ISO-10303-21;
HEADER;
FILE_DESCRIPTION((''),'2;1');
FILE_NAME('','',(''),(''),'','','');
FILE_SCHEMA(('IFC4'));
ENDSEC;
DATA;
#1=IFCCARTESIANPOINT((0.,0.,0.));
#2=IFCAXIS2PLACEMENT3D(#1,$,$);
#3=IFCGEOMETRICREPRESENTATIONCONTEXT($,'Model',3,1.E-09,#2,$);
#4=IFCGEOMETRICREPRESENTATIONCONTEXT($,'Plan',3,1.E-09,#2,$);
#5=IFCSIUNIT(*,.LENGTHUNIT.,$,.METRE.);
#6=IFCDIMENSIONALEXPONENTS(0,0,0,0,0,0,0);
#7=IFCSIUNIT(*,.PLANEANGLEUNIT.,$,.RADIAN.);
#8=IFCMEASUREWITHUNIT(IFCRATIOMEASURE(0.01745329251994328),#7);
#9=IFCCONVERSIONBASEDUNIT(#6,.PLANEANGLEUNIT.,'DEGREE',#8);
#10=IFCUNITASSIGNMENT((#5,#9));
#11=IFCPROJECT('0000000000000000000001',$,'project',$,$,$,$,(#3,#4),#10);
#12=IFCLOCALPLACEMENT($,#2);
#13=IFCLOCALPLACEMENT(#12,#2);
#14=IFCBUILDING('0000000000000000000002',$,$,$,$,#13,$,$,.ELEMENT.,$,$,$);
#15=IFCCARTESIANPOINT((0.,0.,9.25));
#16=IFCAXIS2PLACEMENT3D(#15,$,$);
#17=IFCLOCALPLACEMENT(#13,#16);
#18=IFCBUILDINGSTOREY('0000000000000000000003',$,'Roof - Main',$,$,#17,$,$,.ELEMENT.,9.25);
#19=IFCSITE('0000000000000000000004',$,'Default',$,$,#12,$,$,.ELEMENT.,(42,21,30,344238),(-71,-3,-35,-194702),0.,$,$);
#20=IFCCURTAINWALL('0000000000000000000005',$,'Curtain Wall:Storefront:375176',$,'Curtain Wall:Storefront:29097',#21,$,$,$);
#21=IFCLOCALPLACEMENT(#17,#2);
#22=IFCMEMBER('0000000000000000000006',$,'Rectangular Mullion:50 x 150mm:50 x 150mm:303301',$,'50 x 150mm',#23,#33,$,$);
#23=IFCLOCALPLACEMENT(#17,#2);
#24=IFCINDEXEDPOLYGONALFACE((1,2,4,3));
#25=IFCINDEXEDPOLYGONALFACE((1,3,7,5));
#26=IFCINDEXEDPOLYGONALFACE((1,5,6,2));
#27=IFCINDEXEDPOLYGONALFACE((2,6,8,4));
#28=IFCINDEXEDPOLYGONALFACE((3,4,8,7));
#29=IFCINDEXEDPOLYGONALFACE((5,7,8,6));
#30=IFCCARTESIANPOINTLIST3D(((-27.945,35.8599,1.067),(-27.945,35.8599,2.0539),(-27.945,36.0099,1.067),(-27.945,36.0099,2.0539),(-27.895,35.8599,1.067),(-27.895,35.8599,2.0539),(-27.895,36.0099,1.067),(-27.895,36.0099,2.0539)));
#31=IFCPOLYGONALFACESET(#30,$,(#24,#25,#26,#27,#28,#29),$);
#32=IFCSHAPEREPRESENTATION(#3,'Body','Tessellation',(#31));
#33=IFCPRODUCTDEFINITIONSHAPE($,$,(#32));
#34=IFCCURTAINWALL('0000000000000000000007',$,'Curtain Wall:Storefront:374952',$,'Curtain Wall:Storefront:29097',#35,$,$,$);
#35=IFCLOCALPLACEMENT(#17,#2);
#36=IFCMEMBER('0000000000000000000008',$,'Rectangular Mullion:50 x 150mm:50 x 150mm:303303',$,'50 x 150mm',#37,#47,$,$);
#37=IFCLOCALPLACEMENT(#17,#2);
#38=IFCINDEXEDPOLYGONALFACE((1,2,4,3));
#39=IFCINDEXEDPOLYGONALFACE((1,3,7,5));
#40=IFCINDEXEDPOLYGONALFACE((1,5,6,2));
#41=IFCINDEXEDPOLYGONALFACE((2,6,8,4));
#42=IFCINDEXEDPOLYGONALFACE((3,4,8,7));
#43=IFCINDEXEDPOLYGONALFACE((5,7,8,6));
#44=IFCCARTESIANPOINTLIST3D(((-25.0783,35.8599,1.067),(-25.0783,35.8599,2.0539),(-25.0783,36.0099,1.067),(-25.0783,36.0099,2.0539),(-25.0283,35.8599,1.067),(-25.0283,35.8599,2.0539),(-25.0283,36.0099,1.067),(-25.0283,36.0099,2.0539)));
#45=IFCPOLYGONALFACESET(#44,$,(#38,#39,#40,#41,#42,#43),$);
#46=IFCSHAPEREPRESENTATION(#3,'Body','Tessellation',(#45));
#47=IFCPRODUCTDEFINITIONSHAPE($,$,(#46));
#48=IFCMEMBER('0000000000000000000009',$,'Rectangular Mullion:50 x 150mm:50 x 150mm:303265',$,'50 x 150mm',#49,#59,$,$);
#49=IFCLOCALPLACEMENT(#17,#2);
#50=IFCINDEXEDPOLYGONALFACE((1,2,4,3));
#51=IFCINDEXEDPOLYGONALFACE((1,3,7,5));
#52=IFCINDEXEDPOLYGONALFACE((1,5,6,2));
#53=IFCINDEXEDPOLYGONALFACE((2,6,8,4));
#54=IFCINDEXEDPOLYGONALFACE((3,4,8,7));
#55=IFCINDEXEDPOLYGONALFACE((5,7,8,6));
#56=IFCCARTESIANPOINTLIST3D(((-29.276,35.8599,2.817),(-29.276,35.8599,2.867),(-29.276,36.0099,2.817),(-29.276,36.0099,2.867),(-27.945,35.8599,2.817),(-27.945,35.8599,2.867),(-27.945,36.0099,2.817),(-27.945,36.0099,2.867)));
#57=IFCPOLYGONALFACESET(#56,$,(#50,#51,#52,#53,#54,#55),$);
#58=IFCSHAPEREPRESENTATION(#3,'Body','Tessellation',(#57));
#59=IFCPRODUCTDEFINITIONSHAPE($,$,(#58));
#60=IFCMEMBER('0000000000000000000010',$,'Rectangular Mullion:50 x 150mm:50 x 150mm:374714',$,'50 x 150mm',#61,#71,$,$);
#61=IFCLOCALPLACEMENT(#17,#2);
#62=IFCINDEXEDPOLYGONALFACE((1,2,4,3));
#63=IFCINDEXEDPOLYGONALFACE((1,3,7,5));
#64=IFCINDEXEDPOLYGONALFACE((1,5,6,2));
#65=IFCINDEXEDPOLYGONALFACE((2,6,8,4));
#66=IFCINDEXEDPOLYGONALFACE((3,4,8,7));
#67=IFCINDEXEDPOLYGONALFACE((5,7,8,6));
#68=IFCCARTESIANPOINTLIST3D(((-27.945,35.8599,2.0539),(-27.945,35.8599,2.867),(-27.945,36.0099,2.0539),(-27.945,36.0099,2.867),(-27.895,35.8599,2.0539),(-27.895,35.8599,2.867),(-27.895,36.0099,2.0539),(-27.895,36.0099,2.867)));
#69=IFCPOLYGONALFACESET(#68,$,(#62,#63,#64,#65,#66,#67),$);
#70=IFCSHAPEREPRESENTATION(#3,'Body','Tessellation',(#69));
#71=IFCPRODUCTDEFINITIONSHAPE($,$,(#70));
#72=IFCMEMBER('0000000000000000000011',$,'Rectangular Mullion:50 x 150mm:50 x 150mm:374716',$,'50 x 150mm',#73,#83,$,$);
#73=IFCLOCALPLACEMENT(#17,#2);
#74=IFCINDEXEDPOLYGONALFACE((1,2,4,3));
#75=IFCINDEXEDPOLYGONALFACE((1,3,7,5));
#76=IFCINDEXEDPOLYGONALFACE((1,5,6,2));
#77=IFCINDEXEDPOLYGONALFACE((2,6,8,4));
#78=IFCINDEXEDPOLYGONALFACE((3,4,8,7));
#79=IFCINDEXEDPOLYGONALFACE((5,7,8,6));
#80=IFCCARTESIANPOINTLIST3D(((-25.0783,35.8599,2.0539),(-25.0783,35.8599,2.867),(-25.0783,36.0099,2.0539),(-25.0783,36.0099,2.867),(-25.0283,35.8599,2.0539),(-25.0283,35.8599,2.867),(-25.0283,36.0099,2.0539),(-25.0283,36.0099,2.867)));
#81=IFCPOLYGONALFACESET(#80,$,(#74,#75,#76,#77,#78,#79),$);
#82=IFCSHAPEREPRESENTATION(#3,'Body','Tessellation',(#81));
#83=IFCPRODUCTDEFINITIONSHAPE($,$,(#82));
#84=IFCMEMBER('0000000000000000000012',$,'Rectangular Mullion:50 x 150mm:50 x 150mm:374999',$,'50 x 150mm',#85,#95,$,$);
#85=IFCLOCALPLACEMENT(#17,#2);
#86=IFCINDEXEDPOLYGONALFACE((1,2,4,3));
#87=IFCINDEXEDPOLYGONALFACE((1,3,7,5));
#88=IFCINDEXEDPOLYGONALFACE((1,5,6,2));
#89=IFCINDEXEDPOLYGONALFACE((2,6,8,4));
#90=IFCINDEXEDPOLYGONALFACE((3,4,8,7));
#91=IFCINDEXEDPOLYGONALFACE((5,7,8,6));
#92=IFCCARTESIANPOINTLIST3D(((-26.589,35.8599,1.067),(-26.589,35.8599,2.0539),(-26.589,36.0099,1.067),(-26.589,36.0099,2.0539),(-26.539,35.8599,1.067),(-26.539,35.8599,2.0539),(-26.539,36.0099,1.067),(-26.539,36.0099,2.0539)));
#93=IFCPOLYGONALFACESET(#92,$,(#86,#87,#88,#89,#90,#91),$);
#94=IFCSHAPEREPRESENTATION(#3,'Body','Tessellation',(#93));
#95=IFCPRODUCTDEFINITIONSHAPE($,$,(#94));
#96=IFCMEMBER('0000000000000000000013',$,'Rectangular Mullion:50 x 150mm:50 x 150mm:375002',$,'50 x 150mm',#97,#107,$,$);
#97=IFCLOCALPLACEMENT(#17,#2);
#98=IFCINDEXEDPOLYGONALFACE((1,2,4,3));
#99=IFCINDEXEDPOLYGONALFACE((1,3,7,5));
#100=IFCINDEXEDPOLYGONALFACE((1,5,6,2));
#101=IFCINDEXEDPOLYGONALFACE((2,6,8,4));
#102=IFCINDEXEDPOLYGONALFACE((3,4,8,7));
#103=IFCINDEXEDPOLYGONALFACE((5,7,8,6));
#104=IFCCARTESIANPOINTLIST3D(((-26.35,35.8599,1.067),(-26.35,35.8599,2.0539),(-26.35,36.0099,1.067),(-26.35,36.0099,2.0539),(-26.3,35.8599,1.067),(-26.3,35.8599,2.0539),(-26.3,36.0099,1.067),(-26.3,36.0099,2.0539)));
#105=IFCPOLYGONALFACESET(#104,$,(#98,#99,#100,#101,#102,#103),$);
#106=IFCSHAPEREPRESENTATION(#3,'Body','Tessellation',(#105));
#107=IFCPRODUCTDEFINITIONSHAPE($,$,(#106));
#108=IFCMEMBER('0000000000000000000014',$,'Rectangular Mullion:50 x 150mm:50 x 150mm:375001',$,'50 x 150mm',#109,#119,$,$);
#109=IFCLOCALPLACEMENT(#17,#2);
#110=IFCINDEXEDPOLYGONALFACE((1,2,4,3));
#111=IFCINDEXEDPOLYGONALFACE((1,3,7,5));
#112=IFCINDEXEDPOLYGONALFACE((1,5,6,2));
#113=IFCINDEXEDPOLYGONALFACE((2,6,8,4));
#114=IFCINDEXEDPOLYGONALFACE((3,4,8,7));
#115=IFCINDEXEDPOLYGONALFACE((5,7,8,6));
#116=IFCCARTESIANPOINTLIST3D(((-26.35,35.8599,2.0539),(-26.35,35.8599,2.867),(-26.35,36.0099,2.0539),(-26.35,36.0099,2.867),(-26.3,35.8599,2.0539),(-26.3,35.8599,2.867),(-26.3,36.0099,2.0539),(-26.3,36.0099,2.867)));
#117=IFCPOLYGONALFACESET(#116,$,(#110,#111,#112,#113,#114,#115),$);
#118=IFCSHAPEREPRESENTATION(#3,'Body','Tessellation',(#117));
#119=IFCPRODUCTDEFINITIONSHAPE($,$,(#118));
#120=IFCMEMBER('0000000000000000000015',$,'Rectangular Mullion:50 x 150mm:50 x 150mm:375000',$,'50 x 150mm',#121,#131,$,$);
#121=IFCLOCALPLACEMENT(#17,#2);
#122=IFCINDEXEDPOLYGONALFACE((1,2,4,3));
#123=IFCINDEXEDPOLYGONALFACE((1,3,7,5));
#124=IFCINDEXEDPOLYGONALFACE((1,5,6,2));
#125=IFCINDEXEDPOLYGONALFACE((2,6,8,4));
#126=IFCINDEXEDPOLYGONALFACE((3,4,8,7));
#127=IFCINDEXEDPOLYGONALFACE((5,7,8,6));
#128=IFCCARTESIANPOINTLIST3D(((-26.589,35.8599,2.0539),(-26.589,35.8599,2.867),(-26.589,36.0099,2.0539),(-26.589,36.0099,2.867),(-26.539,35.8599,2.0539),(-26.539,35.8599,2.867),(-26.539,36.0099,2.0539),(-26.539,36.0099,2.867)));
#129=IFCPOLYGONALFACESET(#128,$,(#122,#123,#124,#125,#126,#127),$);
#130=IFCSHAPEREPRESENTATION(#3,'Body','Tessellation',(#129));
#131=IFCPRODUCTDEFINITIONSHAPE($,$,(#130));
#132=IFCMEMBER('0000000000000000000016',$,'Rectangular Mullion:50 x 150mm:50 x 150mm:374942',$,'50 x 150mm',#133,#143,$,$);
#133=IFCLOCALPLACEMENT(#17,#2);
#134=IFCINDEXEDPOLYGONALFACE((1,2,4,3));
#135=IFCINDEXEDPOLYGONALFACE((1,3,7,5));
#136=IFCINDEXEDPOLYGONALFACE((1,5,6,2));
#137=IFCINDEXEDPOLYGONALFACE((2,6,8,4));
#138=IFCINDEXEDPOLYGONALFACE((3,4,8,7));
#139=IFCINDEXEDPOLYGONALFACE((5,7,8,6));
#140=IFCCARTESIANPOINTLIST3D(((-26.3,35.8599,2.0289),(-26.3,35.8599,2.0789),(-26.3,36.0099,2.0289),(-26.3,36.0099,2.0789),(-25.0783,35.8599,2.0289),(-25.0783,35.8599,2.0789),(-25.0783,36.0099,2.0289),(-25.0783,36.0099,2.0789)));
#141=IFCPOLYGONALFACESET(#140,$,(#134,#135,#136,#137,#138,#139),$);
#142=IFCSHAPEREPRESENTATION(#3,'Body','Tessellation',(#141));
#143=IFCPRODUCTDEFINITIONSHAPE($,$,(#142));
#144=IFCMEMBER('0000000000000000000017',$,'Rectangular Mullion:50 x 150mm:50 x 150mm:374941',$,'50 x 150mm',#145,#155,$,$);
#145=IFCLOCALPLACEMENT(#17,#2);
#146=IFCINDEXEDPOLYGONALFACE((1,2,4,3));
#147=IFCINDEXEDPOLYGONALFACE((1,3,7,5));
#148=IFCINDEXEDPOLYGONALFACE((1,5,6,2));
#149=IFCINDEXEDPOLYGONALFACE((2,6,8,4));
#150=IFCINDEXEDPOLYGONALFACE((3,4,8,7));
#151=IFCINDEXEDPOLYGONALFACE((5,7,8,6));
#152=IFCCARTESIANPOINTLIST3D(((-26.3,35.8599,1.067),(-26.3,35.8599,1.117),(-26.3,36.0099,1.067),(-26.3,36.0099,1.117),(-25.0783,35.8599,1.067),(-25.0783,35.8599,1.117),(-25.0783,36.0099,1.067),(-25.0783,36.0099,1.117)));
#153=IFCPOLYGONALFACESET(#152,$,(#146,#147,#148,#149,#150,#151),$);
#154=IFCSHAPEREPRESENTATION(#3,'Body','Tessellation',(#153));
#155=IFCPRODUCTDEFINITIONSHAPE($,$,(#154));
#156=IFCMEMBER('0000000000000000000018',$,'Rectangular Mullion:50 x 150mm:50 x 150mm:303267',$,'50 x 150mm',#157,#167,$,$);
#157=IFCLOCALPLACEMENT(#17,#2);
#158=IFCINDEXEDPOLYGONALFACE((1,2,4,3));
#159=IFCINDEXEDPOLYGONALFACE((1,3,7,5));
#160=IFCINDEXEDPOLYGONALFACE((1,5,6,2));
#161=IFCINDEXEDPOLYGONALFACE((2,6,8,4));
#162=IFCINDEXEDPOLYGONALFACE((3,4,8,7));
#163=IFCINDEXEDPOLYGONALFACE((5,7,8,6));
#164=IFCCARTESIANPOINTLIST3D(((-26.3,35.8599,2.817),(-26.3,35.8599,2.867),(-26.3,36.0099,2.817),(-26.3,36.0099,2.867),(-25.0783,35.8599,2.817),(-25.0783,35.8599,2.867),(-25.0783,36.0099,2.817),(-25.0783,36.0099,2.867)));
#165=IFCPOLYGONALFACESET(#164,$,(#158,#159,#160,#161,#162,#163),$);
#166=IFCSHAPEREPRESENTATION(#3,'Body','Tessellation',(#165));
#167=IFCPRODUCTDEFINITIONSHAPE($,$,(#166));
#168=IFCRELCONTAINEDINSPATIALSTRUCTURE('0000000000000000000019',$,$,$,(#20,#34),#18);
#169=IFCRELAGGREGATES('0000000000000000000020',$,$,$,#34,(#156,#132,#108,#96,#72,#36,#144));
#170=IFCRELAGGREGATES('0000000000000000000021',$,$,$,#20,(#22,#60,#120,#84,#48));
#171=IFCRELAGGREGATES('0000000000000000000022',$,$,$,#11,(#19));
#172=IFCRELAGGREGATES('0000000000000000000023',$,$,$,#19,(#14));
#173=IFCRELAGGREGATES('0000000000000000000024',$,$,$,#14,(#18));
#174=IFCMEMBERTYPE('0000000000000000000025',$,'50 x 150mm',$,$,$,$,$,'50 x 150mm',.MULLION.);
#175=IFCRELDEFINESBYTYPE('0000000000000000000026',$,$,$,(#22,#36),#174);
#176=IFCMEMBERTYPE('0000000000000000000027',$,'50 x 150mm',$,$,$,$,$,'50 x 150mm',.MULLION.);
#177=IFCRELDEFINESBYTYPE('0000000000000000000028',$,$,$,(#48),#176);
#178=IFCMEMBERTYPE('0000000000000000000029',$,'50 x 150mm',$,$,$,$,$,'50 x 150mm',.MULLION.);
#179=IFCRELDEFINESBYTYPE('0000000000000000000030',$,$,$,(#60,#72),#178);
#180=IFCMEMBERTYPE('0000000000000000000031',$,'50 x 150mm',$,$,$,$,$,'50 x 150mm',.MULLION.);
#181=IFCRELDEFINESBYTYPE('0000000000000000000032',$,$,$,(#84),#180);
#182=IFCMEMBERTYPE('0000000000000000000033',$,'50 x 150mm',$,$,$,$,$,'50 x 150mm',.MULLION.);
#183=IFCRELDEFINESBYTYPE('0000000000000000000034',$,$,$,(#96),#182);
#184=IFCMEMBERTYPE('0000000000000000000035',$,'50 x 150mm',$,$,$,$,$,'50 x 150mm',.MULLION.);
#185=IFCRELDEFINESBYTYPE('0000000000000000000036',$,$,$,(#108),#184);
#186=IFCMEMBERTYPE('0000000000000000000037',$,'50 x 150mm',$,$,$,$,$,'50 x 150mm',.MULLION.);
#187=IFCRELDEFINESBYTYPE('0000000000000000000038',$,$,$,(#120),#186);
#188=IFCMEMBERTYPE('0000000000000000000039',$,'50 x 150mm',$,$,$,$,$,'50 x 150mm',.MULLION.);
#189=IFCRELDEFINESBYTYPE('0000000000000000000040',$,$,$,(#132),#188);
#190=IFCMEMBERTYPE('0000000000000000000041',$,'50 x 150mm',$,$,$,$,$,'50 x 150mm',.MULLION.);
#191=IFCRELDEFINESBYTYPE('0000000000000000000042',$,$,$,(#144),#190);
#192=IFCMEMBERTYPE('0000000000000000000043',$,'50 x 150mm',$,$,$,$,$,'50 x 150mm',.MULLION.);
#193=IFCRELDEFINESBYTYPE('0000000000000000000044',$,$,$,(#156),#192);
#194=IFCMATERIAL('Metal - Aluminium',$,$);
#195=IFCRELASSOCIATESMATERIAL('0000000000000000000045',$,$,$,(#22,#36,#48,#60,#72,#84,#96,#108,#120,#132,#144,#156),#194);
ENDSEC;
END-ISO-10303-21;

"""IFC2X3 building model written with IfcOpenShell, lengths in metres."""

from ifc_helpers import new_model, entity, si_unit, converted_unit, frame, origin, origin_2d_with_axis, place, context, project, spatial, rectangle, extrude, source, transform, mapped, material, type_object, type_shapes, element, aggregate, save


model = new_model("IFC2X3")

# Units and contexts
model_context = context("Model", 3, precision=1e-09, world=origin())
plan_context = context("Plan", 3, precision=1e-09, world=origin())
ifc_project = project(units=[si_unit("LENGTHUNIT", "METRE"), converted_unit("PLANEANGLEUNIT", "DEGREE", entity("IfcRatioMeasure", 0.01745329251994328), si_unit("PLANEANGLEUNIT", "RADIAN"), dimensions=[0, 0, 0, 0, 0, 0, 0])], contexts=[model_context, plan_context])

# Site, building, storey
site_placement = place(None, origin())
site = spatial("IfcSite", under=ifc_project, at=site_placement, Name="Default", CompositionType="ELEMENT", RefLatitude=(42, 21, 30, 344238), RefLongitude=(-71, -3, -35, -194702), RefElevation=0.0)
building_placement = place(site_placement, origin())
building = spatial("IfcBuilding", under=site, at=building_placement, CompositionType="ELEMENT")
storey_placement = place(building_placement, frame((0.0, 0.0, 9.25)))
storey = spatial("IfcBuildingStorey", under=building, at=storey_placement, Name="Roof - Main", CompositionType="ELEMENT", Elevation=9.25)

# Curtain walls, members
curtain_wall_1_placement = place(storey_placement, origin())
curtain_wall_1 = element("IfcCurtainWall", 1, at=curtain_wall_1_placement, inside=storey, Name="Curtain Wall:Storefront:375176", ObjectType="Curtain Wall:Storefront:29097")
ifc_material_1 = material(Name="Metal - Aluminium")
member_type_1 = type_object("IfcMemberType", Name="50 x 150mm", ElementType="50 x 150mm", PredefinedType="MULLION")
shared_shape_1 = source(origin(), model_context, "Body", "SweptSolid", [
    extrude(rectangle(XDim=0.05, YDim=0.15, at=origin_2d_with_axis()), frame((0.0, 0.0, -0.9869), z_axis=(0.0, 0.0, 1.0), x_axis=(-1.0, 0.0, 0.0)), (0.0, 0.0, 1.0), 0.9869),
])
type_shapes(member_type_1, [shared_shape_1])
member_1_placement = place(storey_placement, frame((-27.92, 35.9349, 1.067), z_axis=(0.0, 0.0, -1.0), x_axis=(1.0, 0.0, 0.0)))
member_1 = element("IfcMember", 2, at=member_1_placement, type_object=member_type_1, material=ifc_material_1, Name="Rectangular Mullion:50 x 150mm:50 x 150mm:303301", ObjectType="50 x 150mm", context=model_context, shape_type="MappedRepresentation", body=[
    mapped(shared_shape_1, transform((0.0, 0.0, 0.0), scale=1.0)),
])
curtain_wall_2_placement = place(storey_placement, origin())
curtain_wall_2 = element("IfcCurtainWall", 3, at=curtain_wall_2_placement, inside=storey, Name="Curtain Wall:Storefront:374952", ObjectType="Curtain Wall:Storefront:29097")
member_2_placement = place(storey_placement, frame((-25.0533, 35.9349, 1.067), z_axis=(0.0, 0.0, -1.0), x_axis=(1.0, 0.0, 0.0)))
member_2 = element("IfcMember", 4, at=member_2_placement, type_object=member_type_1, material=ifc_material_1, Name="Rectangular Mullion:50 x 150mm:50 x 150mm:303303", ObjectType="50 x 150mm", context=model_context, shape_type="MappedRepresentation", body=[
    mapped(shared_shape_1, transform((0.0, 0.0, 0.0), scale=1.0)),
])

# Members
member_type_2 = type_object("IfcMemberType", Name="50 x 150mm", ElementType="50 x 150mm", PredefinedType="MULLION")
shared_shape_2 = source(origin(), model_context, "Body", "SweptSolid", [
    extrude(rectangle(XDim=0.05, YDim=0.15, at=origin_2d_with_axis()), frame((-0.025, 0.0, -1.331), z_axis=(0.0, 0.0, 1.0), x_axis=(-1.0, 0.0, 0.0)), (0.0, 0.0, 1.0), 1.331),
])
type_shapes(member_type_2, [shared_shape_2])
member_3_placement = place(storey_placement, frame((-27.945, 35.9349, 2.867), z_axis=(1.0, 0.0, 0.0), x_axis=(0.0, 0.0, 1.0)))
member_3 = element("IfcMember", 5, at=member_3_placement, type_object=member_type_2, material=ifc_material_1, Name="Rectangular Mullion:50 x 150mm:50 x 150mm:303265", ObjectType="50 x 150mm", context=model_context, shape_type="MappedRepresentation", body=[
    mapped(shared_shape_2, transform((0.0, 0.0, 0.0), scale=1.0)),
])
member_type_3 = type_object("IfcMemberType", Name="50 x 150mm", ElementType="50 x 150mm", PredefinedType="MULLION")
shared_shape_3 = source(origin(), model_context, "Body", "SweptSolid", [
    extrude(rectangle(XDim=0.05, YDim=0.15, at=origin_2d_with_axis()), frame((0.0, 0.0, -0.8131), z_axis=(0.0, 0.0, 1.0), x_axis=(-1.0, 0.0, 0.0)), (0.0, 0.0, 1.0), 0.8131),
])
type_shapes(member_type_3, [shared_shape_3])
member_4_placement = place(storey_placement, frame((-27.92, 35.9349, 2.0539), z_axis=(0.0, 0.0, -1.0), x_axis=(1.0, 0.0, 0.0)))
member_4 = element("IfcMember", 6, at=member_4_placement, type_object=member_type_3, material=ifc_material_1, Name="Rectangular Mullion:50 x 150mm:50 x 150mm:374714", ObjectType="50 x 150mm", context=model_context, shape_type="MappedRepresentation", body=[
    mapped(shared_shape_3, transform((0.0, 0.0, 0.0), scale=1.0)),
])
member_5_placement = place(storey_placement, frame((-25.0533, 35.9349, 2.0539), z_axis=(0.0, 0.0, -1.0), x_axis=(1.0, 0.0, 0.0)))
member_5 = element("IfcMember", 7, at=member_5_placement, type_object=member_type_3, material=ifc_material_1, Name="Rectangular Mullion:50 x 150mm:50 x 150mm:374716", ObjectType="50 x 150mm", context=model_context, shape_type="MappedRepresentation", body=[
    mapped(shared_shape_3, transform((0.0, 0.0, 0.0), scale=1.0)),
])
member_type_4 = type_object("IfcMemberType", Name="50 x 150mm", ElementType="50 x 150mm", PredefinedType="MULLION")
shared_shape_4 = source(origin(), model_context, "Body", "SweptSolid", [
    extrude(rectangle(XDim=0.05, YDim=0.15, at=origin_2d_with_axis()), frame((-0.025, 0.0, -0.9869), z_axis=(0.0, 0.0, 1.0), x_axis=(-1.0, 0.0, 0.0)), (0.0, 0.0, 1.0), 0.9869),
])
type_shapes(member_type_4, [shared_shape_4])
member_6_placement = place(storey_placement, frame((-26.539, 35.9349, 1.067), z_axis=(0.0, 0.0, -1.0), x_axis=(1.0, 0.0, 0.0)))
member_6 = element("IfcMember", 8, at=member_6_placement, type_object=member_type_4, material=ifc_material_1, Name="Rectangular Mullion:50 x 150mm:50 x 150mm:374999", ObjectType="50 x 150mm", context=model_context, shape_type="MappedRepresentation", body=[
    mapped(shared_shape_4, transform((0.0, 0.0, 0.0), scale=1.0)),
])
member_type_5 = type_object("IfcMemberType", Name="50 x 150mm", ElementType="50 x 150mm", PredefinedType="MULLION")
shared_shape_5 = source(origin(), model_context, "Body", "SweptSolid", [
    extrude(rectangle(XDim=0.05, YDim=0.15, at=origin_2d_with_axis()), frame((-0.025, 0.0, -0.9869), z_axis=(0.0, 0.0, 1.0), x_axis=(-1.0, 0.0, 0.0)), (0.0, 0.0, 1.0), 0.9869),
])
type_shapes(member_type_5, [shared_shape_5])
member_7_placement = place(storey_placement, frame((-26.35, 35.9349, 2.0539), z_axis=(0.0, 0.0, 1.0), x_axis=(-1.0, 0.0, 0.0)))
member_7 = element("IfcMember", 9, at=member_7_placement, type_object=member_type_5, material=ifc_material_1, Name="Rectangular Mullion:50 x 150mm:50 x 150mm:375002", ObjectType="50 x 150mm", context=model_context, shape_type="MappedRepresentation", body=[
    mapped(shared_shape_5, transform((0.0, 0.0, 0.0), scale=1.0)),
])
member_type_6 = type_object("IfcMemberType", Name="50 x 150mm", ElementType="50 x 150mm", PredefinedType="MULLION")
shared_shape_6 = source(origin(), model_context, "Body", "SweptSolid", [
    extrude(rectangle(XDim=0.05, YDim=0.15, at=origin_2d_with_axis()), frame((-0.025, 0.0, -0.8131), z_axis=(0.0, 0.0, 1.0), x_axis=(-1.0, 0.0, 0.0)), (0.0, 0.0, 1.0), 0.8131),
])
type_shapes(member_type_6, [shared_shape_6])
member_8_placement = place(storey_placement, frame((-26.35, 35.9349, 2.867), z_axis=(0.0, 0.0, 1.0), x_axis=(-1.0, 0.0, 0.0)))
member_8 = element("IfcMember", 10, at=member_8_placement, type_object=member_type_6, material=ifc_material_1, Name="Rectangular Mullion:50 x 150mm:50 x 150mm:375001", ObjectType="50 x 150mm", context=model_context, shape_type="MappedRepresentation", body=[
    mapped(shared_shape_6, transform((0.0, 0.0, 0.0), scale=1.0)),
])
member_type_7 = type_object("IfcMemberType", Name="50 x 150mm", ElementType="50 x 150mm", PredefinedType="MULLION")
shared_shape_7 = source(origin(), model_context, "Body", "SweptSolid", [
    extrude(rectangle(XDim=0.05, YDim=0.15, at=origin_2d_with_axis()), frame((-0.025, 0.0, -0.8131), z_axis=(0.0, 0.0, 1.0), x_axis=(-1.0, 0.0, 0.0)), (0.0, 0.0, 1.0), 0.8131),
])
type_shapes(member_type_7, [shared_shape_7])
member_9_placement = place(storey_placement, frame((-26.539, 35.9349, 2.0539), z_axis=(0.0, 0.0, -1.0), x_axis=(1.0, 0.0, 0.0)))
member_9 = element("IfcMember", 11, at=member_9_placement, type_object=member_type_7, material=ifc_material_1, Name="Rectangular Mullion:50 x 150mm:50 x 150mm:375000", ObjectType="50 x 150mm", context=model_context, shape_type="MappedRepresentation", body=[
    mapped(shared_shape_7, transform((0.0, 0.0, 0.0), scale=1.0)),
])
member_type_8 = type_object("IfcMemberType", Name="50 x 150mm", ElementType="50 x 150mm", PredefinedType="MULLION")
shared_shape_8 = source(origin(), model_context, "Body", "SweptSolid", [
    extrude(rectangle(XDim=0.05, YDim=0.15, at=origin_2d_with_axis()), frame((0.0, 0.0, -1.2217), z_axis=(0.0, 0.0, 1.0), x_axis=(-1.0, 0.0, 0.0)), (0.0, 0.0, 1.0), 1.2217),
])
type_shapes(member_type_8, [shared_shape_8])
member_10_placement = place(storey_placement, frame((-25.0783, 35.9349, 2.0539), z_axis=(1.0, 0.0, 0.0), x_axis=(0.0, 0.0, 1.0)))
member_10 = element("IfcMember", 12, at=member_10_placement, type_object=member_type_8, material=ifc_material_1, Name="Rectangular Mullion:50 x 150mm:50 x 150mm:374942", ObjectType="50 x 150mm", context=model_context, shape_type="MappedRepresentation", body=[
    mapped(shared_shape_8, transform((0.0, 0.0, 0.0), scale=1.0)),
])
member_type_9 = type_object("IfcMemberType", Name="50 x 150mm", ElementType="50 x 150mm", PredefinedType="MULLION")
shared_shape_9 = source(origin(), model_context, "Body", "SweptSolid", [
    extrude(rectangle(XDim=0.05, YDim=0.15, at=origin_2d_with_axis()), frame((-0.025, 0.0, -1.2217), z_axis=(0.0, 0.0, 1.0), x_axis=(-1.0, 0.0, 0.0)), (0.0, 0.0, 1.0), 1.2217),
])
type_shapes(member_type_9, [shared_shape_9])
member_11_placement = place(storey_placement, frame((-26.3, 35.9349, 1.067), z_axis=(-1.0, 0.0, 0.0), x_axis=(0.0, 0.0, -1.0)))
member_11 = element("IfcMember", 13, at=member_11_placement, type_object=member_type_9, material=ifc_material_1, Name="Rectangular Mullion:50 x 150mm:50 x 150mm:374941", ObjectType="50 x 150mm", context=model_context, shape_type="MappedRepresentation", body=[
    mapped(shared_shape_9, transform((0.0, 0.0, 0.0), scale=1.0)),
])
member_type_10 = type_object("IfcMemberType", Name="50 x 150mm", ElementType="50 x 150mm", PredefinedType="MULLION")
shared_shape_10 = source(origin(), model_context, "Body", "SweptSolid", [
    extrude(rectangle(XDim=0.05, YDim=0.15, at=origin_2d_with_axis()), frame((-0.025, 0.0, -1.2217), z_axis=(0.0, 0.0, 1.0), x_axis=(-1.0, 0.0, 0.0)), (0.0, 0.0, 1.0), 1.2217),
])
type_shapes(member_type_10, [shared_shape_10])
member_12_placement = place(storey_placement, frame((-25.0783, 35.9349, 2.867), z_axis=(1.0, 0.0, 0.0), x_axis=(0.0, 0.0, 1.0)))
member_12 = element("IfcMember", 14, at=member_12_placement, type_object=member_type_10, material=ifc_material_1, Name="Rectangular Mullion:50 x 150mm:50 x 150mm:303267", ObjectType="50 x 150mm", context=model_context, shape_type="MappedRepresentation", body=[
    mapped(shared_shape_10, transform((0.0, 0.0, 0.0), scale=1.0)),
])

aggregate(curtain_wall_2, [member_12, member_10, member_8, member_7, member_5, member_2, member_11])
aggregate(curtain_wall_1, [member_1, member_4, member_9, member_6, member_3])

save(model, "model.ifc")
